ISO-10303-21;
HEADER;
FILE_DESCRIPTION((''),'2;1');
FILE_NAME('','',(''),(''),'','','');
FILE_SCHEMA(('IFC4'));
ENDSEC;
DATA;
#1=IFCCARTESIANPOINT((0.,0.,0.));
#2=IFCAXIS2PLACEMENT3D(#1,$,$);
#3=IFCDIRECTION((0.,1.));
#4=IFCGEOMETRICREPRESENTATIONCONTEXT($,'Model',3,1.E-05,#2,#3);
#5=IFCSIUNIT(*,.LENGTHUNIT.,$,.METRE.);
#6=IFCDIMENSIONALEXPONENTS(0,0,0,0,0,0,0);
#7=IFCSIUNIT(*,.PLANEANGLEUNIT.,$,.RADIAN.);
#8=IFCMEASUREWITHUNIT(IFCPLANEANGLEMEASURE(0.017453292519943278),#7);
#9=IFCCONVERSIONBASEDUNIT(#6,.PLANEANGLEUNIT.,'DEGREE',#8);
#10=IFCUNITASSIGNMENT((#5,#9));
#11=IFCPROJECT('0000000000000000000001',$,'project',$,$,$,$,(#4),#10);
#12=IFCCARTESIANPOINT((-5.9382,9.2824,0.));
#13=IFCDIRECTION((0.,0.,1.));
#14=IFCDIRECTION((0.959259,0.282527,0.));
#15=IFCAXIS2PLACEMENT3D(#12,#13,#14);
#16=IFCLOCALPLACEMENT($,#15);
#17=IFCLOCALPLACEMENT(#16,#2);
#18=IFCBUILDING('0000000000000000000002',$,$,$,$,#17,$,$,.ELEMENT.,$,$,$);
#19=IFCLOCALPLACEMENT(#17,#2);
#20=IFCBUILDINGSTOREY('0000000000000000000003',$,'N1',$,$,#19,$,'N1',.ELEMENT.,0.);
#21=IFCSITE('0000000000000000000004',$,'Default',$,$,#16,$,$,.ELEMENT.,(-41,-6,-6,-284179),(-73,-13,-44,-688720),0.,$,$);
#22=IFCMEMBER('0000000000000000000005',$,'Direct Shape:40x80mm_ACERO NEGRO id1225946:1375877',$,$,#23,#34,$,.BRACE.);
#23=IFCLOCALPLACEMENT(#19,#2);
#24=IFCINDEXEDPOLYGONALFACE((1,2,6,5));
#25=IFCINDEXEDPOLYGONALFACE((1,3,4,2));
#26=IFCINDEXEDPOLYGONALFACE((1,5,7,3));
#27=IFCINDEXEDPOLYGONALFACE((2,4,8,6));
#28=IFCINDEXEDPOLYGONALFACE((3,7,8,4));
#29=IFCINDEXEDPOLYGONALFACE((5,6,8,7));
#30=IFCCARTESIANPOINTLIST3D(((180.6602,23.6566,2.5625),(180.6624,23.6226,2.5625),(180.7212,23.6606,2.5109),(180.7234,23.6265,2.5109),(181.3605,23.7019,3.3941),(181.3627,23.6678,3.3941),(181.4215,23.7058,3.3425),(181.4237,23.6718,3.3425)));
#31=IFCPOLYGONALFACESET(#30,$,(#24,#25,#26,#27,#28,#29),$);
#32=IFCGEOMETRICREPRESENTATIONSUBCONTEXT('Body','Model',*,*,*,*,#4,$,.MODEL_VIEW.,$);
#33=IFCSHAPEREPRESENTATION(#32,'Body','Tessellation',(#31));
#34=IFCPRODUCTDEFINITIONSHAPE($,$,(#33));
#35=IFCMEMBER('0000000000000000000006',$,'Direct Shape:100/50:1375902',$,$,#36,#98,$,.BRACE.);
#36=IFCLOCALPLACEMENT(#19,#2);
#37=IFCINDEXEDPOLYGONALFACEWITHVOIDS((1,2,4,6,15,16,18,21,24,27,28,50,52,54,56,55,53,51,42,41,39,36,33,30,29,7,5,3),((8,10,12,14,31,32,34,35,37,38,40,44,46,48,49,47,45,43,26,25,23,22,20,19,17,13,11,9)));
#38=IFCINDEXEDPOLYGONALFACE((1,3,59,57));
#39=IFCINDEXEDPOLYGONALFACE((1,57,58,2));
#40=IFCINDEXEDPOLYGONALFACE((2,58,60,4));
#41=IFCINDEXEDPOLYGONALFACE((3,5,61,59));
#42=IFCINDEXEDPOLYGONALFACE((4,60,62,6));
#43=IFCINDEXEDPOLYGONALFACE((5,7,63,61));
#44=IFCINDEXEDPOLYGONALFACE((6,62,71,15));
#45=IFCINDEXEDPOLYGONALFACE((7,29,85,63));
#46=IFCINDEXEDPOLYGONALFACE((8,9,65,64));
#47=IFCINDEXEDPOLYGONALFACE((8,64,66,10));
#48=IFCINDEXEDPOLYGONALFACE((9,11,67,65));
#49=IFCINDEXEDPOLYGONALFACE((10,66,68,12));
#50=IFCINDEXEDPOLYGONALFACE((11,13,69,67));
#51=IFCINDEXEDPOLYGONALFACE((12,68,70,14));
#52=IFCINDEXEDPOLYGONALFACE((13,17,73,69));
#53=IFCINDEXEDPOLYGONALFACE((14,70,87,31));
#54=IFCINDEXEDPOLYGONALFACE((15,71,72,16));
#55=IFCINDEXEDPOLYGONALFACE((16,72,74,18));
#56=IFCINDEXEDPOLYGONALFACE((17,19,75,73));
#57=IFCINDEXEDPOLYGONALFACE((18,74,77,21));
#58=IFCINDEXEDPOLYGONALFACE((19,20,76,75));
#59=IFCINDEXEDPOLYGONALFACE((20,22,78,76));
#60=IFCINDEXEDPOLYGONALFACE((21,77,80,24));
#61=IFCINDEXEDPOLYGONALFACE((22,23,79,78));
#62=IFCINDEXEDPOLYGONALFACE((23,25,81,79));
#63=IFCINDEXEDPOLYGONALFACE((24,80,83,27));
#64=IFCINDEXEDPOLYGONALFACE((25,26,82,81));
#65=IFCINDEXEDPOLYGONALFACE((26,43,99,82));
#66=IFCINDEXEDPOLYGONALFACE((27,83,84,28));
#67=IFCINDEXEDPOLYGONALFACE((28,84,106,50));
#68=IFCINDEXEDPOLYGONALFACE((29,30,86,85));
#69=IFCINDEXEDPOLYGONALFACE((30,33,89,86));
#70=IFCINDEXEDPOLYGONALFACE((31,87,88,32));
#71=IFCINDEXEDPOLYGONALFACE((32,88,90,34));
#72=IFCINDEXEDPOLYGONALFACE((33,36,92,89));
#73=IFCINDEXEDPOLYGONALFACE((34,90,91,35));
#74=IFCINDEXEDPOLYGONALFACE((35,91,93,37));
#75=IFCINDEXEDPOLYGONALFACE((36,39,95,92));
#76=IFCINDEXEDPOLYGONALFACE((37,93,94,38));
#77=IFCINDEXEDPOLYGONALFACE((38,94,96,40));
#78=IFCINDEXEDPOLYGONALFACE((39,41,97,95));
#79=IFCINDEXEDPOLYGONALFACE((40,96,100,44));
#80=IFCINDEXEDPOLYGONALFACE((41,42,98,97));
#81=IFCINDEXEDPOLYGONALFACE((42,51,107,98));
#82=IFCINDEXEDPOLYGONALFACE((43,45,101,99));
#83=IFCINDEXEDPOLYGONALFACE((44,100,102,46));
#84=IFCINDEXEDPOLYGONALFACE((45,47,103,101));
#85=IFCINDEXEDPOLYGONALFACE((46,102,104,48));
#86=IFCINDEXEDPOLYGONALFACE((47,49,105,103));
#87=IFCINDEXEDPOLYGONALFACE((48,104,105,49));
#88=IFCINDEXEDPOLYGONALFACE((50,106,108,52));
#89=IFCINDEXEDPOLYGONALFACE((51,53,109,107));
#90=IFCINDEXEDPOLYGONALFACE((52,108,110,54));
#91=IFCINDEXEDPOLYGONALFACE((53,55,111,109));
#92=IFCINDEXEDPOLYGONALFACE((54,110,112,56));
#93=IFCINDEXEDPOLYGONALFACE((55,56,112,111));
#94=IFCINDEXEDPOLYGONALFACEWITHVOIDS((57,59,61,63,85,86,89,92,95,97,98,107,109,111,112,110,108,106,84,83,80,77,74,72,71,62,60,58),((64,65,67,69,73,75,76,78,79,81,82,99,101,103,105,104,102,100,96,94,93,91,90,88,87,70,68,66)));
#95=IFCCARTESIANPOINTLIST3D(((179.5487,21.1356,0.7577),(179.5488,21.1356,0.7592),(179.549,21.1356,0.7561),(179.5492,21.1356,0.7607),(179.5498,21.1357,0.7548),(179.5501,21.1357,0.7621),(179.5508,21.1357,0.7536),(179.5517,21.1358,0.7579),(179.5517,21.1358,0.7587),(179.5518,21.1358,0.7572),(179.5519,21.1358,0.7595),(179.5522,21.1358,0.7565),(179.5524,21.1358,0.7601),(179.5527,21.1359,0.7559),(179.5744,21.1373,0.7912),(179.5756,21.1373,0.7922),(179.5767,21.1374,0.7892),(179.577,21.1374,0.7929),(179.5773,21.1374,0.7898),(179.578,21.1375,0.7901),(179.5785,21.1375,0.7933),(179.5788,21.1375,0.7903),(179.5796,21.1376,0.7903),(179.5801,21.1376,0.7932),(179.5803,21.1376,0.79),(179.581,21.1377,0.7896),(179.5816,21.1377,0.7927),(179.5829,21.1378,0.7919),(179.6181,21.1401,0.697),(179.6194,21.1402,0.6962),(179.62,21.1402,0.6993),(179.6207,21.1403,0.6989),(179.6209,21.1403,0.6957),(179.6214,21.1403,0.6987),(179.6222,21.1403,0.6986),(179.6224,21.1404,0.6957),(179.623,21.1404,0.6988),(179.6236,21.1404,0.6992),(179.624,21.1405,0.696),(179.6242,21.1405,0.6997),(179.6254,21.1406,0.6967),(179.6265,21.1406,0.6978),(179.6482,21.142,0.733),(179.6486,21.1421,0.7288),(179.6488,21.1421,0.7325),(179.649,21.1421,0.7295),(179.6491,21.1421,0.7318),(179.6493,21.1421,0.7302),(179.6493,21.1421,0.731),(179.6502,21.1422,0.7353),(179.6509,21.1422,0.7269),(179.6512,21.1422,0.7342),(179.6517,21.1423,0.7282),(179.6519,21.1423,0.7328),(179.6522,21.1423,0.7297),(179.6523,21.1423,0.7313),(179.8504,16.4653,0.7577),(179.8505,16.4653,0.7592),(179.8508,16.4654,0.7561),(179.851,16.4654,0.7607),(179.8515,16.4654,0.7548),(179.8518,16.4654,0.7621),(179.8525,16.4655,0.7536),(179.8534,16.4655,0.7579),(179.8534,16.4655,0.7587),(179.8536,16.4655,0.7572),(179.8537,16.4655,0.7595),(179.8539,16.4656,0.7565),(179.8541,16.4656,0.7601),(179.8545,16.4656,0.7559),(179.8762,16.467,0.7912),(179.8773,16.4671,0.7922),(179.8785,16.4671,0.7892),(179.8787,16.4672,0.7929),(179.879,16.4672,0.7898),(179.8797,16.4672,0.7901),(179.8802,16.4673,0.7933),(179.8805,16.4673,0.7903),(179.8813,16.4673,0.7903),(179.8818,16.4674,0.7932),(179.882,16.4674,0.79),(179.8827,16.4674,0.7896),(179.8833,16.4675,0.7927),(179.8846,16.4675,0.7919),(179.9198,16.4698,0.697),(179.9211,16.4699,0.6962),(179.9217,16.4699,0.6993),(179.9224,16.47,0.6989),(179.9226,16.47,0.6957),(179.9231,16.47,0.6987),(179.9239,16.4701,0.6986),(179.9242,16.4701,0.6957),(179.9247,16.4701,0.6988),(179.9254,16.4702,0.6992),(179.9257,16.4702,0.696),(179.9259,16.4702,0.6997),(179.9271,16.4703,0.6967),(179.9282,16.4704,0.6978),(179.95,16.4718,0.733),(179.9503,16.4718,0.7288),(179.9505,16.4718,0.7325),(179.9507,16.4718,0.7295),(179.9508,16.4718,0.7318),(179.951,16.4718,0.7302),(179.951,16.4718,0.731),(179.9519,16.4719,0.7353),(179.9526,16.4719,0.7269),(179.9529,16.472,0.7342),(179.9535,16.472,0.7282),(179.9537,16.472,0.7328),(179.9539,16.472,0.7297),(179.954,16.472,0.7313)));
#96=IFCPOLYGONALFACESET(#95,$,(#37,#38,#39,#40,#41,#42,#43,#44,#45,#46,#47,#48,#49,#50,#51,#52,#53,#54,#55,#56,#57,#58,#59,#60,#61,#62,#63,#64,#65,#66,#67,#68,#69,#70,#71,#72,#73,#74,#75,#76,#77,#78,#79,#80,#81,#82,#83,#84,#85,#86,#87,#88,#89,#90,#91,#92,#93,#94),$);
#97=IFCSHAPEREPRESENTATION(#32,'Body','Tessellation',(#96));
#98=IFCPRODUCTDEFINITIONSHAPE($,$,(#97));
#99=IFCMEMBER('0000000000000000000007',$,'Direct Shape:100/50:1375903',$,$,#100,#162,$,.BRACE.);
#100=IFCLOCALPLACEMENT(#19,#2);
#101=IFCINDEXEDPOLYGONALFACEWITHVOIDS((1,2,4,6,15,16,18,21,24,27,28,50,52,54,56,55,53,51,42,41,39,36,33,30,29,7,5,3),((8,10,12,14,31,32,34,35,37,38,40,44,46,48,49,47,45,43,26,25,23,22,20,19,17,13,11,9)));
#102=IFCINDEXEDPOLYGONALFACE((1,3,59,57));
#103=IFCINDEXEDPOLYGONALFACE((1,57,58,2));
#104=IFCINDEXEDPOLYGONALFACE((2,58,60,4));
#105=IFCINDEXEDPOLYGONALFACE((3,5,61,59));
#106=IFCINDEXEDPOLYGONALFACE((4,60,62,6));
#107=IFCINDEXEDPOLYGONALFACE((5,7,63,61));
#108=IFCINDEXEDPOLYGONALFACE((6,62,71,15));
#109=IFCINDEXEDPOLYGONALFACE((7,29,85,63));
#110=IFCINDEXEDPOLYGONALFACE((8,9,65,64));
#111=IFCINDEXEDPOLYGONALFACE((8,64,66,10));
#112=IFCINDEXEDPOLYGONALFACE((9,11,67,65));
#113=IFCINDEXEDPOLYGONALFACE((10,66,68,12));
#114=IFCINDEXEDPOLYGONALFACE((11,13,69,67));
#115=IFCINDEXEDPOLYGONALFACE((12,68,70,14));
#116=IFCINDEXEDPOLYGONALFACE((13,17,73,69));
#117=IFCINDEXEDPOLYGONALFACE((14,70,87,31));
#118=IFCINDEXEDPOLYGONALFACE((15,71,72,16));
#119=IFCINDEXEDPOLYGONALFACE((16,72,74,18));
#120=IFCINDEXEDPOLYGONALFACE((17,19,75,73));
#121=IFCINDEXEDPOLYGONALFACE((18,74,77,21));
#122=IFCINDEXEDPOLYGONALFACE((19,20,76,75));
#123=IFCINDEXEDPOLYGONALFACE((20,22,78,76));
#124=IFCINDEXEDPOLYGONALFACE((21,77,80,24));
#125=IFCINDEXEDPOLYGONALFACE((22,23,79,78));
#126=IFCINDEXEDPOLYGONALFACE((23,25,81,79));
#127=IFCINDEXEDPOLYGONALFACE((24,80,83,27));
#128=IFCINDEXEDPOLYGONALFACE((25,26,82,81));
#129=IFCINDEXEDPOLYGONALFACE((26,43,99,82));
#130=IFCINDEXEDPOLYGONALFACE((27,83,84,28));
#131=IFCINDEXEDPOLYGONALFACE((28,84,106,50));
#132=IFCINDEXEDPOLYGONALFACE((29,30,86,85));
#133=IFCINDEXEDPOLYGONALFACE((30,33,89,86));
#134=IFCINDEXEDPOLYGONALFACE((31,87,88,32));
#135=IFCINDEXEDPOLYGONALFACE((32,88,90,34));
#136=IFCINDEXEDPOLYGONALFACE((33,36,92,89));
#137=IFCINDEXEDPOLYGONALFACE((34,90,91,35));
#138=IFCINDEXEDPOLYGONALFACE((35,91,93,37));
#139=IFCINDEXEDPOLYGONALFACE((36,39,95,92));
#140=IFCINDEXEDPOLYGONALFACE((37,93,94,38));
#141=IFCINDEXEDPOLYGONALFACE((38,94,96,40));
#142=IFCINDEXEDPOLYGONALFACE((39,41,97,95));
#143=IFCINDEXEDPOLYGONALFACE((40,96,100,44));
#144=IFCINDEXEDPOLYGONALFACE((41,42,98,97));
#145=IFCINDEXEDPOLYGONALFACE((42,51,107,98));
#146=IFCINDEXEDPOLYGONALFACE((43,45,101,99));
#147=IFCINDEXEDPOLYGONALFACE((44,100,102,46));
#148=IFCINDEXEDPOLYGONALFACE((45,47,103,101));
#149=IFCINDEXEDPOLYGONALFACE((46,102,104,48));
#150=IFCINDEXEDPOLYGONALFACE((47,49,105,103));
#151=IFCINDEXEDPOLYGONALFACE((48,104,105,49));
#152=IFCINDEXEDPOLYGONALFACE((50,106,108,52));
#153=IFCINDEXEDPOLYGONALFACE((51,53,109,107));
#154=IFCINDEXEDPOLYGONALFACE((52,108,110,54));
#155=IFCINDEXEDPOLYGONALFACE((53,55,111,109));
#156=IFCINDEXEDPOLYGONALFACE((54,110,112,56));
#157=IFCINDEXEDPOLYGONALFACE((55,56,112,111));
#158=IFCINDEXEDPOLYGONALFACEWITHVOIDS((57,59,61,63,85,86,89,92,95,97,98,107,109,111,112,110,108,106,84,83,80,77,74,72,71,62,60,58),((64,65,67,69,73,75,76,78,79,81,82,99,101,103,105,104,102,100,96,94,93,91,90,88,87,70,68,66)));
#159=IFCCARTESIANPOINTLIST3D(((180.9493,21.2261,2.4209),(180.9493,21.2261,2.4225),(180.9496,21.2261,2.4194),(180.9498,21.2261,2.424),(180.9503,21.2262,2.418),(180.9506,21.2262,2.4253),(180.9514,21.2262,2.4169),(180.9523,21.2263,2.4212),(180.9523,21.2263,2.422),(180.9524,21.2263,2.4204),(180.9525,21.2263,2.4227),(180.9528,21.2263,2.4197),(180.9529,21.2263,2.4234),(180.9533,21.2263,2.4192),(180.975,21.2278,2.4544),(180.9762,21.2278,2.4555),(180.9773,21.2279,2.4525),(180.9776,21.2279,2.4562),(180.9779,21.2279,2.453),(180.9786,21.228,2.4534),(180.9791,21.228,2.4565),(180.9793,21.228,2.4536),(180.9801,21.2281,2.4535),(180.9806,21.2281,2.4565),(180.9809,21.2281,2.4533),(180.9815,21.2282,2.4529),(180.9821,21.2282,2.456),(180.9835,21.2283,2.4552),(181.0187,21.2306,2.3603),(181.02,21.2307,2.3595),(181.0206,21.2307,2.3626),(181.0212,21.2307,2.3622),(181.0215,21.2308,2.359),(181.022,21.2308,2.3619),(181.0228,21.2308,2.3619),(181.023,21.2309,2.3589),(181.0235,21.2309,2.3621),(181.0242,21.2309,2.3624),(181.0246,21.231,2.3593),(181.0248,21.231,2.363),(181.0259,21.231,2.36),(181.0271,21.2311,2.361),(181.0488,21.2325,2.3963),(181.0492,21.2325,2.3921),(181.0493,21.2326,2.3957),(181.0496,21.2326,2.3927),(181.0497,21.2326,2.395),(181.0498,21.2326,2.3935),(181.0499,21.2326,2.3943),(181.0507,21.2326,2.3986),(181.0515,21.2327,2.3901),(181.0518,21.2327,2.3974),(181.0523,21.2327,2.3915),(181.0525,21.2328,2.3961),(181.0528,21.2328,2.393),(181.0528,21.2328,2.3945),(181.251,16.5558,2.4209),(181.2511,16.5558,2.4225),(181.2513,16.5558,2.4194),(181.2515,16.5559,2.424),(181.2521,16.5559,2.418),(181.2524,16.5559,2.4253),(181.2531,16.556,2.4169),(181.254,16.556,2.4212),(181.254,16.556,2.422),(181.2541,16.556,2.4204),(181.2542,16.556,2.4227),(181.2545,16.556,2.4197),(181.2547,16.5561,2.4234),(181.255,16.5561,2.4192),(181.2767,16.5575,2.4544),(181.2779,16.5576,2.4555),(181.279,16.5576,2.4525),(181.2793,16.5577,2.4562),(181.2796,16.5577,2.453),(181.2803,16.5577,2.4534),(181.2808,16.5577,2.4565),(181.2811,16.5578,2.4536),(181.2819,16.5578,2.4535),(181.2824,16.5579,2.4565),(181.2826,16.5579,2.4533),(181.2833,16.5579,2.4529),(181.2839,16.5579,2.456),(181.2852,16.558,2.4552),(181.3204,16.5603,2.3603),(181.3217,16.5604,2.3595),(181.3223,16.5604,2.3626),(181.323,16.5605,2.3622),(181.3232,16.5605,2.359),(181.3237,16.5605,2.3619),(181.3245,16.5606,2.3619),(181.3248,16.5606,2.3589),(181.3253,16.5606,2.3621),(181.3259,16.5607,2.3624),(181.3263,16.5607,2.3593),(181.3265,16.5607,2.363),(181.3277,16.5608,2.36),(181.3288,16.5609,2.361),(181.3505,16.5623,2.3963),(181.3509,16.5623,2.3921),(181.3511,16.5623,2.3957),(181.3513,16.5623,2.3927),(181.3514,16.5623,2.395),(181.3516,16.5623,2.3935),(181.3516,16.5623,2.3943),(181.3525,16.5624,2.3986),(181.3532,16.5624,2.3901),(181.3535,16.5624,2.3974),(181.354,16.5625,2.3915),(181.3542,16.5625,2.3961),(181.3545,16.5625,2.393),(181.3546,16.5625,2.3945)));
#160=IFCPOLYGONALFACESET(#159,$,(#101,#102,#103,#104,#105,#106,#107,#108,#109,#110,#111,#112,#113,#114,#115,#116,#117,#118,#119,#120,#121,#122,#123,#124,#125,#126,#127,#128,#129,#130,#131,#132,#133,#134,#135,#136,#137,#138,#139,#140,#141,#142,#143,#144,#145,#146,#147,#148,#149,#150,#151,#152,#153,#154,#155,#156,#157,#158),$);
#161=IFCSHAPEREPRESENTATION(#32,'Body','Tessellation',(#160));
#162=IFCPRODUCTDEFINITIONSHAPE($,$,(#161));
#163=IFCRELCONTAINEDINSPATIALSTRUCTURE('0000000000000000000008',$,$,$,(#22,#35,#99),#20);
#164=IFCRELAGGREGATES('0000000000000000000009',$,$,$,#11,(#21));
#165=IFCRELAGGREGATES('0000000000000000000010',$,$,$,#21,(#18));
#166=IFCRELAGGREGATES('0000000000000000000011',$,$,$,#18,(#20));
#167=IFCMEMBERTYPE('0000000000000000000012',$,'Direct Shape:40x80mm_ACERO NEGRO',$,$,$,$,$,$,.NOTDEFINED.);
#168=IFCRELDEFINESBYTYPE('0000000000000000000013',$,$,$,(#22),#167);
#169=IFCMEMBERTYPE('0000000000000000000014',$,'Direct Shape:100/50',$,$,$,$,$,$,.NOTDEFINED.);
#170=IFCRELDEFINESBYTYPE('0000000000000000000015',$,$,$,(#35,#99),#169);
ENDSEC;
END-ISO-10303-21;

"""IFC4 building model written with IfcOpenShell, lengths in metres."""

from ifc_helpers import new_model, entity, si_unit, converted_unit, direction, frame, frame_2d, origin, place, context, subcontext, project, spatial, polyline, circle_curve, parameter, trimmed, segment, composite_curve, rectangle, outline, extrude, type_object, element, save


model = new_model("IFC4")

# Units and contexts
model_context = context("Model", 3, precision=1e-05, world=origin(), true_north=direction((0.0, 1.0)))
body_context = subcontext(model_context, "Body", "Model", "MODEL_VIEW")
ifc_project = project(units=[si_unit("LENGTHUNIT", "METRE"), converted_unit("PLANEANGLEUNIT", "DEGREE", entity("IfcPlaneAngleMeasure", 0.017453292519943278), si_unit("PLANEANGLEUNIT", "RADIAN"), dimensions=[0, 0, 0, 0, 0, 0, 0])], contexts=[model_context])

# Site, building, storey
site_placement = place(None, frame((-5.9382, 9.2824, 0.0), z_axis=(0.0, 0.0, 1.0), x_axis=(0.959259, 0.282527, 0.0)))
site = spatial("IfcSite", under=ifc_project, at=site_placement, Name="Default", CompositionType="ELEMENT", RefLatitude=(-41, -6, -6, -284179), RefLongitude=(-73, -13, -44, -688720), RefElevation=0.0)
building_placement = place(site_placement, origin())
building = spatial("IfcBuilding", under=site, at=building_placement, CompositionType="ELEMENT")
storey_placement = place(building_placement, origin())
storey = spatial("IfcBuildingStorey", under=building, at=storey_placement, Name="N1", LongName="N1", CompositionType="ELEMENT", Elevation=0.0)

# Members
member_type_1 = type_object("IfcMemberType", Name="Direct Shape:40x80mm_ACERO NEGRO", PredefinedType="NOTDEFINED")
member_1_placement = place(storey_placement, origin())
element("IfcMember", 1, at=member_1_placement, inside=storey, type_object=member_type_1, Name="Direct Shape:40x80mm_ACERO NEGRO id1225946:1375877", PredefinedType="BRACE", context=body_context, shape_type="SweptSolid", body=[
    extrude(rectangle(XDim=0.08, YDim=0.0341, at=frame_2d((0.0, 0.0), x_axis=(0.0, 1.0))), frame((180.6918, 23.6416, 2.5367), z_axis=(0.643515, 0.041575, 0.764304), x_axis=(0.064471, -0.99792, 0.0)), (0.0, 0.0, 1.0), 1.0881),
])
member_type_2 = type_object("IfcMemberType", Name="Direct Shape:100/50", PredefinedType="NOTDEFINED")
member_2_placement = place(storey_placement, origin())
element("IfcMember", 2, at=member_2_placement, inside=storey, type_object=member_type_2, Name="Direct Shape:100/50:1375902", PredefinedType="BRACE", context=body_context, shape_type="SweptSolid", body=[
    extrude(outline(composite_curve([segment(trimmed(circle_curve(frame_2d((-0.019, -0.044), x_axis=(1.0, 0.0)), 0.006), [parameter(180.0)], [parameter(270.0)], True, "PARAMETER"), True, "CONTINUOUS"), segment(polyline([(-0.019, -0.05), (0.019, -0.05)]), True, "CONTINUOUS"), segment(trimmed(circle_curve(frame_2d((0.019, -0.044), x_axis=(1.0, 0.0)), 0.006), [parameter(270.0)], [parameter(0.0)], True, "PARAMETER"), True, "CONTINUOUS"), segment(polyline([(0.025, -0.044), (0.025, 0.044)]), True, "CONTINUOUS"), segment(trimmed(circle_curve(frame_2d((0.019, 0.044), x_axis=(1.0, 0.0)), 0.006), [parameter(360.0)], [parameter(90.0)], True, "PARAMETER"), True, "CONTINUOUS"), segment(polyline([(0.019, 0.05), (-0.019, 0.05)]), True, "CONTINUOUS"), segment(trimmed(circle_curve(frame_2d((-0.019, 0.044), x_axis=(1.0, 0.0)), 0.006), [parameter(90.0)], [parameter(180.0)], True, "PARAMETER"), True, "CONTINUOUS"), segment(polyline([(-0.025, 0.044), (-0.025, -0.044)]), True, "CONTINUOUS")], self_intersect=False), holes=[composite_curve([segment(polyline([(0.019, -0.047), (-0.019, -0.047)]), True, "CONTINUOUS"), segment(trimmed(circle_curve(frame_2d((-0.019, -0.044), x_axis=(1.0, 0.0)), 0.003), [parameter(180.0)], [parameter(270.0)], True, "PARAMETER"), False, "CONTINUOUS"), segment(polyline([(-0.022, -0.044), (-0.022, 0.044)]), True, "CONTINUOUS"), segment(trimmed(circle_curve(frame_2d((-0.019, 0.044), x_axis=(1.0, 0.0)), 0.003), [parameter(90.0)], [parameter(180.0)], True, "PARAMETER"), False, "CONTINUOUS"), segment(polyline([(-0.019, 0.047), (0.019, 0.047)]), True, "CONTINUOUS"), segment(trimmed(circle_curve(frame_2d((0.019, 0.044), x_axis=(1.0, 0.0)), 0.003), [parameter(0.0)], [parameter(90.0)], True, "PARAMETER"), False, "CONTINUOUS"), segment(polyline([(0.022, 0.044), (0.022, -0.044)]), True, "CONTINUOUS"), segment(trimmed(circle_curve(frame_2d((0.019, -0.044), x_axis=(1.0, 0.0)), 0.003), [parameter(270.0)], [parameter(0.0)], True, "PARAMETER"), False, "CONTINUOUS")], self_intersect=False)]), frame((179.9022, 16.4687, 0.7445), z_axis=(-0.064471, 0.99792, 0.0), x_axis=(0.64145, 0.041441, 0.766044)), (0.0, 0.0, 1.0), 4.68),
])
member_3_placement = place(storey_placement, origin())
element("IfcMember", 3, at=member_3_placement, inside=storey, type_object=member_type_2, Name="Direct Shape:100/50:1375903", PredefinedType="BRACE", context=body_context, shape_type="SweptSolid", body=[
    extrude(outline(composite_curve([segment(trimmed(circle_curve(frame_2d((-0.019, -0.044), x_axis=(1.0, 0.0)), 0.006), [parameter(180.0)], [parameter(270.0)], True, "PARAMETER"), True, "CONTINUOUS"), segment(polyline([(-0.019, -0.05), (0.019, -0.05)]), True, "CONTINUOUS"), segment(trimmed(circle_curve(frame_2d((0.019, -0.044), x_axis=(1.0, 0.0)), 0.006), [parameter(270.0)], [parameter(0.0)], True, "PARAMETER"), True, "CONTINUOUS"), segment(polyline([(0.025, -0.044), (0.025, 0.044)]), True, "CONTINUOUS"), segment(trimmed(circle_curve(frame_2d((0.019, 0.044), x_axis=(1.0, 0.0)), 0.006), [parameter(360.0)], [parameter(90.0)], True, "PARAMETER"), True, "CONTINUOUS"), segment(polyline([(0.019, 0.05), (-0.019, 0.05)]), True, "CONTINUOUS"), segment(trimmed(circle_curve(frame_2d((-0.019, 0.044), x_axis=(1.0, 0.0)), 0.006), [parameter(90.0)], [parameter(180.0)], True, "PARAMETER"), True, "CONTINUOUS"), segment(polyline([(-0.025, 0.044), (-0.025, -0.044)]), True, "CONTINUOUS")], self_intersect=False), holes=[composite_curve([segment(polyline([(0.019, -0.047), (-0.019, -0.047)]), True, "CONTINUOUS"), segment(trimmed(circle_curve(frame_2d((-0.019, -0.044), x_axis=(1.0, 0.0)), 0.003), [parameter(180.0)], [parameter(270.0)], True, "PARAMETER"), False, "CONTINUOUS"), segment(polyline([(-0.022, -0.044), (-0.022, 0.044)]), True, "CONTINUOUS"), segment(trimmed(circle_curve(frame_2d((-0.019, 0.044), x_axis=(1.0, 0.0)), 0.003), [parameter(90.0)], [parameter(180.0)], True, "PARAMETER"), False, "CONTINUOUS"), segment(polyline([(-0.019, 0.047), (0.019, 0.047)]), True, "CONTINUOUS"), segment(trimmed(circle_curve(frame_2d((0.019, 0.044), x_axis=(1.0, 0.0)), 0.003), [parameter(0.0)], [parameter(90.0)], True, "PARAMETER"), False, "CONTINUOUS"), segment(polyline([(0.022, 0.044), (0.022, -0.044)]), True, "CONTINUOUS"), segment(trimmed(circle_curve(frame_2d((0.019, -0.044), x_axis=(1.0, 0.0)), 0.003), [parameter(270.0)], [parameter(0.0)], True, "PARAMETER"), False, "CONTINUOUS")], self_intersect=False)]), frame((181.3028, 16.5592, 2.4077), z_axis=(-0.064471, 0.99792, 0.0), x_axis=(0.64145, 0.041441, 0.766044)), (0.0, 0.0, 1.0), 4.68),
])

save(model, "model.ifc")
